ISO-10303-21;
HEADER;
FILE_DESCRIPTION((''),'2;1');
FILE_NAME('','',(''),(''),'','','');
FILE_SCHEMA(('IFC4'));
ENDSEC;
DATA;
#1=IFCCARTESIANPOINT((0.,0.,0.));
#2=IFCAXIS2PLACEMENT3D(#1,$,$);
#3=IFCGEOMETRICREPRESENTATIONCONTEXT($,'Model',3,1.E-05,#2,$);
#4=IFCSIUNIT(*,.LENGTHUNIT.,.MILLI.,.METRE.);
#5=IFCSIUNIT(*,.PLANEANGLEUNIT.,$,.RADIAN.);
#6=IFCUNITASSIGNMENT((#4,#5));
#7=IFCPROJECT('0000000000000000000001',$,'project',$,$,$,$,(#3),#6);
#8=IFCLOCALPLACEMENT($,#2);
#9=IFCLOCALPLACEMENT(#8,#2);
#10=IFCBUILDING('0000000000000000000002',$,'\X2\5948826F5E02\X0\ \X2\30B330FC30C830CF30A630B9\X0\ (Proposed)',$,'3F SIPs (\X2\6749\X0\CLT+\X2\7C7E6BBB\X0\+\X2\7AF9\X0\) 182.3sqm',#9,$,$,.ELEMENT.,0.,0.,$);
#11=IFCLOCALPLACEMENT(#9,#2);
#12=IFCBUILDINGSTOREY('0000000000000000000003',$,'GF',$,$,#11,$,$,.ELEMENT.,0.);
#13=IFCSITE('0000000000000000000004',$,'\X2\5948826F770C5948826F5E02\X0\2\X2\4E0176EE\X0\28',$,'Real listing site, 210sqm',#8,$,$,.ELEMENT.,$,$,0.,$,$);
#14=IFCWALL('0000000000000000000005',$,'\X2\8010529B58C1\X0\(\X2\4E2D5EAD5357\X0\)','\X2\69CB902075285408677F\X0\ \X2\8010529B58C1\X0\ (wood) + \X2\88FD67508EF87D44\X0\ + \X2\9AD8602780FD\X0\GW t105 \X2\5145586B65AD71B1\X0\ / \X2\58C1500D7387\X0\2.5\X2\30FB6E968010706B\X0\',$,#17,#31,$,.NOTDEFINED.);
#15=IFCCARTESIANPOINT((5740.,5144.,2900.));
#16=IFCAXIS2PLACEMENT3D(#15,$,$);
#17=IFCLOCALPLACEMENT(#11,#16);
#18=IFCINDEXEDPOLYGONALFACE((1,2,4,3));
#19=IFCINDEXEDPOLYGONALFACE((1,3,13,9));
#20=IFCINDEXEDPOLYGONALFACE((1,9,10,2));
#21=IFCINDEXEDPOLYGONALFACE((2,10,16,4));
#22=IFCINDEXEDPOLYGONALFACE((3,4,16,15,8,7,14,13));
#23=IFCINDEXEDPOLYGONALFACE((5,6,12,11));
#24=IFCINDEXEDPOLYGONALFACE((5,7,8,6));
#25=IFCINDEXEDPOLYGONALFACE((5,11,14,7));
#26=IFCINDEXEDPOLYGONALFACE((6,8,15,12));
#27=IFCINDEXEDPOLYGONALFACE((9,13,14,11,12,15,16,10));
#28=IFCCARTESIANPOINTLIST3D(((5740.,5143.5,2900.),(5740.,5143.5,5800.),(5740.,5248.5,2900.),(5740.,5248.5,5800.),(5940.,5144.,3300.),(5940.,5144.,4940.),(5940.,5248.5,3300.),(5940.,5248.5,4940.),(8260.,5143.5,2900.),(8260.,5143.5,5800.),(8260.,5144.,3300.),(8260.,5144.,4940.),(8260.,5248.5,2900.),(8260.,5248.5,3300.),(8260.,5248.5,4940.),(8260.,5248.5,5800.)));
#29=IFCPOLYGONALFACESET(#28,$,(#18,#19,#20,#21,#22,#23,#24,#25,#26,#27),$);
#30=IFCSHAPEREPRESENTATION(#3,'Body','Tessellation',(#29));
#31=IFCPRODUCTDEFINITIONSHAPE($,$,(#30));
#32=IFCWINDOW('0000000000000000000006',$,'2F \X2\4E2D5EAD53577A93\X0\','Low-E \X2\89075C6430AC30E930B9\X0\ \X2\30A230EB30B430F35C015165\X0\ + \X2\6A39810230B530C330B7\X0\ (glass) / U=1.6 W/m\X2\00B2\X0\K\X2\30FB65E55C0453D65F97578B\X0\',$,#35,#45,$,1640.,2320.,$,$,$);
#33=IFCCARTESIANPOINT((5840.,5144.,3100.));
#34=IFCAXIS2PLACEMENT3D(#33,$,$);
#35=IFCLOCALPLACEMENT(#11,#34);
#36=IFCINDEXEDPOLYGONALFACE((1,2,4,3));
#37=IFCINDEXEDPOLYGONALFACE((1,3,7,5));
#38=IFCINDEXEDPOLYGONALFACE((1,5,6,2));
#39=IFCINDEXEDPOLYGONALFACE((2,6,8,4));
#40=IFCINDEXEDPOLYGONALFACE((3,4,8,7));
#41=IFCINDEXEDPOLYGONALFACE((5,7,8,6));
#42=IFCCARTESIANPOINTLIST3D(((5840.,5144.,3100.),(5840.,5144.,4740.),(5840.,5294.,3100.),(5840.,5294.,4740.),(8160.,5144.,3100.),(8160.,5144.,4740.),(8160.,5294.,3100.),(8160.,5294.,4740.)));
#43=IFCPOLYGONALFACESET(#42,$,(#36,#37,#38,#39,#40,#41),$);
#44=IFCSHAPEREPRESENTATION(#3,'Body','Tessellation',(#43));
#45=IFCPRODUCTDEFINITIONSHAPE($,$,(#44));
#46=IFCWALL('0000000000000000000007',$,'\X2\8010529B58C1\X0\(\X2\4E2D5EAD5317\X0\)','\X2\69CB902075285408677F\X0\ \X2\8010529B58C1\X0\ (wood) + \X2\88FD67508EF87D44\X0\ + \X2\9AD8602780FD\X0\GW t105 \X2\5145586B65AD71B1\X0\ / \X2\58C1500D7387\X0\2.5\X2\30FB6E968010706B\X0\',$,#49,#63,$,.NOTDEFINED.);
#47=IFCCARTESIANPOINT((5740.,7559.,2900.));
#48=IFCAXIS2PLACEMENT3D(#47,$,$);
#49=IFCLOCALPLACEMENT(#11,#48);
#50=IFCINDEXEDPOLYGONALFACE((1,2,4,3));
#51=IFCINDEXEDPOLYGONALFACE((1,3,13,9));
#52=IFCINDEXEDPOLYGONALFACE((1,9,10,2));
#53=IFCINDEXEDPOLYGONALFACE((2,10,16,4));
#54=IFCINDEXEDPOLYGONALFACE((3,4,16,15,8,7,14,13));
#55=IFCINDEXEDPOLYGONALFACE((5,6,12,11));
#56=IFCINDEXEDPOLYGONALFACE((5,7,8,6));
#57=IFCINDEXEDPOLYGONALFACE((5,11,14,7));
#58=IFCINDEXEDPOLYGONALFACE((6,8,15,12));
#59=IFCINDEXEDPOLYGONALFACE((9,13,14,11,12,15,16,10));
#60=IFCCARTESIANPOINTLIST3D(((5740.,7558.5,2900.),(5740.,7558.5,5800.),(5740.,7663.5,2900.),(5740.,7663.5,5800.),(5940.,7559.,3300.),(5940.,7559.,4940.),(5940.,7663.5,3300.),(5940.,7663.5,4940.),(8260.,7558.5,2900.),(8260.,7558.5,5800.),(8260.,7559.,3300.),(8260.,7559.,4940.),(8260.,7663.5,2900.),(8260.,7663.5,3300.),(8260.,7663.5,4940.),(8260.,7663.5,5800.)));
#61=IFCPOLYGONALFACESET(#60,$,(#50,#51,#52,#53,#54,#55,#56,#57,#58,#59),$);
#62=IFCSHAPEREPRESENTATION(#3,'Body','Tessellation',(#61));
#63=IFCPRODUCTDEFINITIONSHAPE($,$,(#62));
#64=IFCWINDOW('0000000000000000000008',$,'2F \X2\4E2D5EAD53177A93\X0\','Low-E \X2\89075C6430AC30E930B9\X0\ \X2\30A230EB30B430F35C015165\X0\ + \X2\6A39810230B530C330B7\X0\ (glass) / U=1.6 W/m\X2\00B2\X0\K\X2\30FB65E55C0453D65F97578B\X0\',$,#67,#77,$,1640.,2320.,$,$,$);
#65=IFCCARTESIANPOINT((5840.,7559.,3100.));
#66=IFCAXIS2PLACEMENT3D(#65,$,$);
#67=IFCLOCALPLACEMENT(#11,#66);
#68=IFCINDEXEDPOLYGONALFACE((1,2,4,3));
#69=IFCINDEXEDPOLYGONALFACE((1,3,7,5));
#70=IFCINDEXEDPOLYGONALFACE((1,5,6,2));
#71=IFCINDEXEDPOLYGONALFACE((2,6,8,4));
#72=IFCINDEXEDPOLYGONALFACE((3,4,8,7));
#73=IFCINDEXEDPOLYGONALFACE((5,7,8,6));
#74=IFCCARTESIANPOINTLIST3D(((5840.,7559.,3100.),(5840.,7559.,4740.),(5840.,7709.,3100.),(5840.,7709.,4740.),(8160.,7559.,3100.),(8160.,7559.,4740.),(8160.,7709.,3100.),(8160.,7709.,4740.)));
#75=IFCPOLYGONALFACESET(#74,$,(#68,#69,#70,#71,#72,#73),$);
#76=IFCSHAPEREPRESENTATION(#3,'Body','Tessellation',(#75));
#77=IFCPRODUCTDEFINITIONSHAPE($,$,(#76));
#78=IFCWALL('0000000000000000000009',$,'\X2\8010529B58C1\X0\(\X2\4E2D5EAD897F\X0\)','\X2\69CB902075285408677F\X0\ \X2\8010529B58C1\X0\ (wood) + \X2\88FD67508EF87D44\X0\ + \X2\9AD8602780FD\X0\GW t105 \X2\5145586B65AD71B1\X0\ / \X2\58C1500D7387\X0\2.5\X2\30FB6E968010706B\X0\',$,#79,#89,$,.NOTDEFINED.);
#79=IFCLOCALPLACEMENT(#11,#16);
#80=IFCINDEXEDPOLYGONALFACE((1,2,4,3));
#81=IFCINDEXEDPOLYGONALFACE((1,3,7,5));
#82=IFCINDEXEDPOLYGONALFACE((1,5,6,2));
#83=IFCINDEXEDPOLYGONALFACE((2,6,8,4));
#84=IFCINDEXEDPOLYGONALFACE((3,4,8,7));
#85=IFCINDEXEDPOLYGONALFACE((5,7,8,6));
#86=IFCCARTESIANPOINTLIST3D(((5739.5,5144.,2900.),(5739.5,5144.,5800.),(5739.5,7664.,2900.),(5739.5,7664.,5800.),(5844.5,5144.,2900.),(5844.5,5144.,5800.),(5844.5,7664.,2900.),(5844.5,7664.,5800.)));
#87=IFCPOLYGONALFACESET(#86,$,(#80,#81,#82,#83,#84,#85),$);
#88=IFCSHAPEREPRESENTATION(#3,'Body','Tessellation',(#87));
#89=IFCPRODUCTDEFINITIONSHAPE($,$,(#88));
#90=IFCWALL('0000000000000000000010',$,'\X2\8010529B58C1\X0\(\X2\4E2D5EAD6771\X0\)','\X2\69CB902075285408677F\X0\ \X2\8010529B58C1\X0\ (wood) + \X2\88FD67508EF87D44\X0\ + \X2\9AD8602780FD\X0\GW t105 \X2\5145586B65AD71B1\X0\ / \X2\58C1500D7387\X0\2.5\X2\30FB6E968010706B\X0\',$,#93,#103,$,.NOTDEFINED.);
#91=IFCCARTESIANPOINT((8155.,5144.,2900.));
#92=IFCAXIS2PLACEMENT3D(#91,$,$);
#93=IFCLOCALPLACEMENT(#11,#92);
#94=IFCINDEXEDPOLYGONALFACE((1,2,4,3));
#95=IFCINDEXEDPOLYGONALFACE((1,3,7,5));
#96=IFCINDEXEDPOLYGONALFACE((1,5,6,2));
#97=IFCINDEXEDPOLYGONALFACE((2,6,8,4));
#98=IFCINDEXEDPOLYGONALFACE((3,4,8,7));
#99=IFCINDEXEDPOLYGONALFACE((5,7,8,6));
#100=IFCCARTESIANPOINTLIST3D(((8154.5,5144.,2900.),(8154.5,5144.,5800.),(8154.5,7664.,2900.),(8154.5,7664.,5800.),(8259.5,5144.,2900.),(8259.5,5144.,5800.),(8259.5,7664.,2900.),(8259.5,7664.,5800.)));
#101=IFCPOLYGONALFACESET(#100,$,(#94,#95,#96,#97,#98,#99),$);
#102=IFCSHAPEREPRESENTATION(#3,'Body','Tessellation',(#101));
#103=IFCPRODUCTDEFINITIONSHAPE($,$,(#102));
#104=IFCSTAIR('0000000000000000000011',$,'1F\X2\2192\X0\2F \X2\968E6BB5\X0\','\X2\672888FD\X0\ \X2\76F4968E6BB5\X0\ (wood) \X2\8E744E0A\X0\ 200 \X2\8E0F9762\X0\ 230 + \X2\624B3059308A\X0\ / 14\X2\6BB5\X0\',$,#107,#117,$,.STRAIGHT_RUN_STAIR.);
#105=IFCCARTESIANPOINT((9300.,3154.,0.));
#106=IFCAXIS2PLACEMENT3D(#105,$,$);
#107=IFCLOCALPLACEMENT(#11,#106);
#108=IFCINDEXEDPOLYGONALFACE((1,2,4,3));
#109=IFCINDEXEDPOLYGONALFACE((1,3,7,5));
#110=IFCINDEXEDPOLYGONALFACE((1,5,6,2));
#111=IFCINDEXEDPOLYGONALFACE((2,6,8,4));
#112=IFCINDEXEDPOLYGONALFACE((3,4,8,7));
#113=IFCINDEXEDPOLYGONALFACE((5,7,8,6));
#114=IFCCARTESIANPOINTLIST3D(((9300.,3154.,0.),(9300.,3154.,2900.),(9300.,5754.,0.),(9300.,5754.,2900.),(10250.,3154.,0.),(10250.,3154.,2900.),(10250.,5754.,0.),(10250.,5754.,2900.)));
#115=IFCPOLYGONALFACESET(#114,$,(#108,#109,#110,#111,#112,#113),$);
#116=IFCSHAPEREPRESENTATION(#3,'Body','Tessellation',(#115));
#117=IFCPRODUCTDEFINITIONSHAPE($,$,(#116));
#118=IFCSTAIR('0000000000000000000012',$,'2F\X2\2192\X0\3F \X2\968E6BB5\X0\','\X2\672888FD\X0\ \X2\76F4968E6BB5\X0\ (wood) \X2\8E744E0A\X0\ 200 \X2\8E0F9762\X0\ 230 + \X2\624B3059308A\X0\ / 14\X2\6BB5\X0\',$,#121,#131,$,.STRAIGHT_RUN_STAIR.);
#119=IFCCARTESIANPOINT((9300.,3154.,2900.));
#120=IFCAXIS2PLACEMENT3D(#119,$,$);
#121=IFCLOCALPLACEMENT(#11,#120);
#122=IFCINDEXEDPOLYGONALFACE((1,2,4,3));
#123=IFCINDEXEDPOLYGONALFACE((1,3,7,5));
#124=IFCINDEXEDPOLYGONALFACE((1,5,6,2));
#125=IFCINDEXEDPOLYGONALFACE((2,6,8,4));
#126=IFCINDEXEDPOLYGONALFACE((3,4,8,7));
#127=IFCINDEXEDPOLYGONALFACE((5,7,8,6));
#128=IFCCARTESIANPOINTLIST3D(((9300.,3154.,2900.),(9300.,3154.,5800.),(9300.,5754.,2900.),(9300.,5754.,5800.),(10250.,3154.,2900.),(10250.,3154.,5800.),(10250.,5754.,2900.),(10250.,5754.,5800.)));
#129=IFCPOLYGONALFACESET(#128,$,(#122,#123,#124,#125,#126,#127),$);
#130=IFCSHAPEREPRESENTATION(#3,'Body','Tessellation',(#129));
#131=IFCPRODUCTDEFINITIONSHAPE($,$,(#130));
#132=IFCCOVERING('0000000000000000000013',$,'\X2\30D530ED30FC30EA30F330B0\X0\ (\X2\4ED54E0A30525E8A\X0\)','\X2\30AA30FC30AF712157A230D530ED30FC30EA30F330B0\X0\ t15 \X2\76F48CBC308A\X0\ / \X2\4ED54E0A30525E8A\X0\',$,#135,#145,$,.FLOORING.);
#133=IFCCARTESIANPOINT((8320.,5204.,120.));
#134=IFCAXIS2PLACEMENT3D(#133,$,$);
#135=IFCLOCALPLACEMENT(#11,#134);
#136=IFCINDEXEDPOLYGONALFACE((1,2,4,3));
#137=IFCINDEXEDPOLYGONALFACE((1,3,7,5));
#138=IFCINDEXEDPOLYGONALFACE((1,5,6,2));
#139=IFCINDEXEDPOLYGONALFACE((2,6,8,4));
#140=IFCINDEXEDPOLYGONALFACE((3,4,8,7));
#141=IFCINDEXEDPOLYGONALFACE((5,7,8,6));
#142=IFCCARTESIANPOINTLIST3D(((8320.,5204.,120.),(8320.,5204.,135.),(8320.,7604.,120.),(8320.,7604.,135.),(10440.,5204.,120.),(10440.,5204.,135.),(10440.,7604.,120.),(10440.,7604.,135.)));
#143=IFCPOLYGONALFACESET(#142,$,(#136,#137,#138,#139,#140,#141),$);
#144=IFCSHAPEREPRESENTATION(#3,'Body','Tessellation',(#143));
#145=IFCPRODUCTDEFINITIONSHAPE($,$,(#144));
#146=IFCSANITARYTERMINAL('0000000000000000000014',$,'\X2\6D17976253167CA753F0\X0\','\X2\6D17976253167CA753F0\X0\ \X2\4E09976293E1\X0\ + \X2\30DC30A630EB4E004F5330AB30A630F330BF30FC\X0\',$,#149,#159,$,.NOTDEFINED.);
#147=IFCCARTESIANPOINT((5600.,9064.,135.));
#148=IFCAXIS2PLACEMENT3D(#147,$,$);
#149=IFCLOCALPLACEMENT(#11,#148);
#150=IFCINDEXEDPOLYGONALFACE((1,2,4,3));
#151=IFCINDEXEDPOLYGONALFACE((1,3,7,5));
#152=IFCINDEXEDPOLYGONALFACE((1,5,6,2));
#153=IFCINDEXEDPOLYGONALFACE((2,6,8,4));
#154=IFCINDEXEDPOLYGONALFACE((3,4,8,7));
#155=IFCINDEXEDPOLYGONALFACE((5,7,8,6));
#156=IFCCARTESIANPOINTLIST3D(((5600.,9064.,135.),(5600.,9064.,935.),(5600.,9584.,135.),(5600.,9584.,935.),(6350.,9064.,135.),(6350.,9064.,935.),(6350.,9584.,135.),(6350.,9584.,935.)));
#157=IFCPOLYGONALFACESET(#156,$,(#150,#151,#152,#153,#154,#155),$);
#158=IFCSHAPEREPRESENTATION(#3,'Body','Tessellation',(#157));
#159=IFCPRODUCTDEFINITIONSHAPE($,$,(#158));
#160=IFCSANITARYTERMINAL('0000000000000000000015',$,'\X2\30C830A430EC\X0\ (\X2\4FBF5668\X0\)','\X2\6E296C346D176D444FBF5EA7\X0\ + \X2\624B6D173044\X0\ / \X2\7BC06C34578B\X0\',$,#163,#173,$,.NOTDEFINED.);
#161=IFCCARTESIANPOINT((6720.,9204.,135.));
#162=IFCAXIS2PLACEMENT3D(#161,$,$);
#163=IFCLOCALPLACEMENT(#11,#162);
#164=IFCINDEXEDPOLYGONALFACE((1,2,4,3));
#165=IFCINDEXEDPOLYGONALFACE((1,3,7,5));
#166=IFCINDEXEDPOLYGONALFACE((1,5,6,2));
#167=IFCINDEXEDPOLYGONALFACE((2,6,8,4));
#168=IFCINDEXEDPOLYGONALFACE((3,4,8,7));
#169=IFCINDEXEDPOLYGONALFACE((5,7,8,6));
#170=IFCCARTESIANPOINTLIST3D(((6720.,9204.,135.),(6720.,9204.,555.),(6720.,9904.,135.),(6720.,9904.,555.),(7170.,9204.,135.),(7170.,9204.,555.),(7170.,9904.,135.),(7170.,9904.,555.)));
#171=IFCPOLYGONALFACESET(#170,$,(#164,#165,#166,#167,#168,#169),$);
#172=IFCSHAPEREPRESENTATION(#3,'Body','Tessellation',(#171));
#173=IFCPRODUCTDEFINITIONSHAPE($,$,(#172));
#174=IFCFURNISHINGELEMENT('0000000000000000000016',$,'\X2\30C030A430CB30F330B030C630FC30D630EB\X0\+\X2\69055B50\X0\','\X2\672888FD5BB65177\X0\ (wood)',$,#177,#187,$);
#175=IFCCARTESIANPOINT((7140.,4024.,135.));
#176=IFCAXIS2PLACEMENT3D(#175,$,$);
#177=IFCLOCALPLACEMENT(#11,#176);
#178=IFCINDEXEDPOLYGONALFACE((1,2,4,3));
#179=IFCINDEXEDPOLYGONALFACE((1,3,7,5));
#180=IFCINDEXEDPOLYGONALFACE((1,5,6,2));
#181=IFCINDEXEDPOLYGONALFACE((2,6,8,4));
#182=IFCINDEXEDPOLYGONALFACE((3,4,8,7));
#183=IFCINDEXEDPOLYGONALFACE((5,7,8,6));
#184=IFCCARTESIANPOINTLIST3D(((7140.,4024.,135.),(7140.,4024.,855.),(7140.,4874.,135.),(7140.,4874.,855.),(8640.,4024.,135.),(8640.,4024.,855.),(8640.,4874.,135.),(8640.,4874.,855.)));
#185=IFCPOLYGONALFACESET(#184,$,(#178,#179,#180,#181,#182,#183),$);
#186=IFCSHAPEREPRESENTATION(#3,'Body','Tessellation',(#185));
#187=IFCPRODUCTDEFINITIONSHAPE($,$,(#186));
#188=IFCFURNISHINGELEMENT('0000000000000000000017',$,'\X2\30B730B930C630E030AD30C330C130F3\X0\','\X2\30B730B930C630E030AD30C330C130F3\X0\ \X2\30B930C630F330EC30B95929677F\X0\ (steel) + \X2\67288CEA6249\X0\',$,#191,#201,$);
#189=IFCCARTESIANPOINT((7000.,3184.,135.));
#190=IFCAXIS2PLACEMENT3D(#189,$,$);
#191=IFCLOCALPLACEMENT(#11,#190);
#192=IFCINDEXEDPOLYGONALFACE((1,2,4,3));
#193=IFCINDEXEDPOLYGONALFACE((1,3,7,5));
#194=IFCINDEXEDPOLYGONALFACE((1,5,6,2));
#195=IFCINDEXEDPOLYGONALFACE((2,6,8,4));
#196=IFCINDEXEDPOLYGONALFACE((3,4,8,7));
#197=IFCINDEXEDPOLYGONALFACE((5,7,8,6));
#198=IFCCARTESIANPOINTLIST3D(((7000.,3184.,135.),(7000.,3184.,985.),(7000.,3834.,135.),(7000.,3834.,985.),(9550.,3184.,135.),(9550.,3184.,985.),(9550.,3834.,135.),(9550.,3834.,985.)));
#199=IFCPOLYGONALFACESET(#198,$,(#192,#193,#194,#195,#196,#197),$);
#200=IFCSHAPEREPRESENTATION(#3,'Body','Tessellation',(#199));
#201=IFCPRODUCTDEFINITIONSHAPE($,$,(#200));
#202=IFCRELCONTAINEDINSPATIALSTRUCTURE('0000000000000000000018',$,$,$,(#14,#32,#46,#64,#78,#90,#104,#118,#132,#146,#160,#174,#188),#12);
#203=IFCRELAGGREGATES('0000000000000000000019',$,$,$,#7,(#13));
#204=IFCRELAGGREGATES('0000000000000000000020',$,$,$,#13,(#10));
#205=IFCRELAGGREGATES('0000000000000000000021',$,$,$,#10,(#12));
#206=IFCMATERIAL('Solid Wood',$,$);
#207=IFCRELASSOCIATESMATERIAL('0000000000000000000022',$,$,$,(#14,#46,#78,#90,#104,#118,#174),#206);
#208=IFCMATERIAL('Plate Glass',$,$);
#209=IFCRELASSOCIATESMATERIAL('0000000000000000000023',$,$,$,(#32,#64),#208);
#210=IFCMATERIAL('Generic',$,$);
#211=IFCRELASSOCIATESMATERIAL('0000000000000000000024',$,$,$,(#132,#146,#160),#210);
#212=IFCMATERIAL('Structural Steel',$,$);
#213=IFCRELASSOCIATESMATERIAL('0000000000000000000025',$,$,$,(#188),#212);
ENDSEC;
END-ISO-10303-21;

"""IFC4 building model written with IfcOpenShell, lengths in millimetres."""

from ifc_helpers import new_model, si_unit, frame, frame_2d, origin, place, context, project, spatial, rectangle, extrude, material, element, fill, save


model = new_model("IFC4")

# Units and contexts
model_context = context("Model", 3, precision=1e-05, world=origin())
ifc_project = project(units=[si_unit("LENGTHUNIT", "METRE", prefix="MILLI"), si_unit("PLANEANGLEUNIT", "RADIAN")], contexts=[model_context])

# Site, building, storey
site_placement = place(None, origin())
site = spatial("IfcSite", under=ifc_project, at=site_placement, Name="奈良県奈良市2丁目28", ObjectType="Real listing site, 210sqm", CompositionType="ELEMENT", RefElevation=0.0)
building_placement = place(site_placement, origin())
building = spatial("IfcBuilding", under=site, at=building_placement, Name="奈良市 コートハウス (Proposed)", ObjectType="3F SIPs (杉CLT+籾殻+竹) 182.3sqm", CompositionType="ELEMENT", ElevationOfRefHeight=0.0, ElevationOfTerrain=0.0)
storey_placement = place(building_placement, origin())
storey = spatial("IfcBuildingStorey", under=building, at=storey_placement, Name="GF", CompositionType="ELEMENT", Elevation=0.0)

# Shared definitions
ifc_material_1 = material(Name="Solid Wood")

# Shared definitions
ifc_material_2 = material(Name="Plate Glass")

# Walls, openings, windows
wall_1_placement = place(storey_placement, frame((5740.0, 5144.0, 2900.0)))
wall_1 = element("IfcWall", 1, at=wall_1_placement, inside=storey, material=ifc_material_1, Name="耐力壁(中庭南)", Description="構造用合板 耐力壁 (wood) + 製材軸組 + 高性能GW t105 充填断熱 / 壁倍率2.5・準耐火", PredefinedType="NOTDEFINED", context=model_context, shape_type="SweptSolid", body=[
    extrude(rectangle(XDim=2520.0, YDim=105.0, at=frame_2d((1260.0, 52.0))), frame((5740.0, 5144.0, 2900.0)), (0.0, 0.0, 1.0), 2900.0),
])
opening_1_placement = place(storey_placement, frame((5840.0, 5144.0, 3100.0)))
opening_1 = element("IfcOpeningElement", 2, at=opening_1_placement, cuts=wall_1, PredefinedType="NOTDEFINED", context=model_context, shape_type="SweptSolid", body=[
    extrude(rectangle(XDim=2320.0, YDim=150.0, at=frame_2d((1160.0, 75.0))), frame((5840.0, 5144.0, 3100.0)), (0.0, 0.0, 1.0), 1640.0),
])
window_1_placement = place(storey_placement, frame((5840.0, 5144.0, 3100.0)))
window_1 = element("IfcWindow", 3, at=window_1_placement, inside=storey, material=ifc_material_2, Name="2F 中庭南窓", Description="Low-E 複層ガラス アルゴン封入 + 樹脂サッシ (glass) / U=1.6 W/m²K・日射取得型", OverallHeight=1640.0, OverallWidth=2320.0, context=model_context, shape_type="SweptSolid", body=[
    extrude(rectangle(XDim=2320.0, YDim=150.0, at=frame_2d((1160.0, 75.0))), frame((5840.0, 5144.0, 3100.0)), (0.0, 0.0, 1.0), 1640.0),
])
fill(opening_1, window_1)
wall_2_placement = place(storey_placement, frame((5740.0, 7559.0, 2900.0)))
wall_2 = element("IfcWall", 4, at=wall_2_placement, inside=storey, material=ifc_material_1, Name="耐力壁(中庭北)", Description="構造用合板 耐力壁 (wood) + 製材軸組 + 高性能GW t105 充填断熱 / 壁倍率2.5・準耐火", PredefinedType="NOTDEFINED", context=model_context, shape_type="SweptSolid", body=[
    extrude(rectangle(XDim=2520.0, YDim=105.0, at=frame_2d((1260.0, 52.0))), frame((5740.0, 7559.0, 2900.0)), (0.0, 0.0, 1.0), 2900.0),
])
opening_2_placement = place(storey_placement, frame((5840.0, 7559.0, 3100.0)))
opening_2 = element("IfcOpeningElement", 5, at=opening_2_placement, cuts=wall_2, PredefinedType="NOTDEFINED", context=model_context, shape_type="SweptSolid", body=[
    extrude(rectangle(XDim=2320.0, YDim=150.0, at=frame_2d((1160.0, 75.0))), frame((5840.0, 7559.0, 3100.0)), (0.0, 0.0, 1.0), 1640.0),
])
window_2_placement = place(storey_placement, frame((5840.0, 7559.0, 3100.0)))
window_2 = element("IfcWindow", 6, at=window_2_placement, inside=storey, material=ifc_material_2, Name="2F 中庭北窓", Description="Low-E 複層ガラス アルゴン封入 + 樹脂サッシ (glass) / U=1.6 W/m²K・日射取得型", OverallHeight=1640.0, OverallWidth=2320.0, context=model_context, shape_type="SweptSolid", body=[
    extrude(rectangle(XDim=2320.0, YDim=150.0, at=frame_2d((1160.0, 75.0))), frame((5840.0, 7559.0, 3100.0)), (0.0, 0.0, 1.0), 1640.0),
])
fill(opening_2, window_2)

# Walls
wall_3_placement = place(storey_placement, frame((5740.0, 5144.0, 2900.0)))
element("IfcWall", 7, at=wall_3_placement, inside=storey, material=ifc_material_1, Name="耐力壁(中庭西)", Description="構造用合板 耐力壁 (wood) + 製材軸組 + 高性能GW t105 充填断熱 / 壁倍率2.5・準耐火", PredefinedType="NOTDEFINED", context=model_context, shape_type="SweptSolid", body=[
    extrude(rectangle(XDim=105.0, YDim=2520.0, at=frame_2d((52.0, 1260.0))), frame((5740.0, 5144.0, 2900.0)), (0.0, 0.0, 1.0), 2900.0),
])
wall_4_placement = place(storey_placement, frame((8155.0, 5144.0, 2900.0)))
element("IfcWall", 8, at=wall_4_placement, inside=storey, material=ifc_material_1, Name="耐力壁(中庭東)", Description="構造用合板 耐力壁 (wood) + 製材軸組 + 高性能GW t105 充填断熱 / 壁倍率2.5・準耐火", PredefinedType="NOTDEFINED", context=model_context, shape_type="SweptSolid", body=[
    extrude(rectangle(XDim=105.0, YDim=2520.0, at=frame_2d((52.0, 1260.0))), frame((8155.0, 5144.0, 2900.0)), (0.0, 0.0, 1.0), 2900.0),
])

# Stairs
stair_1_placement = place(storey_placement, frame((9300.0, 3154.0, 0.0)))
element("IfcStair", 9, at=stair_1_placement, inside=storey, material=ifc_material_1, Name="1F→2F 階段", Description="木製 直階段 (wood) 蹴上 200 踏面 230 + 手すり / 14段", PredefinedType="STRAIGHT_RUN_STAIR", context=model_context, shape_type="SweptSolid", body=[
    extrude(rectangle(XDim=950.0, YDim=2600.0, at=frame_2d((475.0, 1300.0))), frame((9300.0, 3154.0, 0.0)), (0.0, 0.0, 1.0), 2900.0),
])
stair_2_placement = place(storey_placement, frame((9300.0, 3154.0, 2900.0)))
element("IfcStair", 10, at=stair_2_placement, inside=storey, material=ifc_material_1, Name="2F→3F 階段", Description="木製 直階段 (wood) 蹴上 200 踏面 230 + 手すり / 14段", PredefinedType="STRAIGHT_RUN_STAIR", context=model_context, shape_type="SweptSolid", body=[
    extrude(rectangle(XDim=950.0, YDim=2600.0, at=frame_2d((475.0, 1300.0))), frame((9300.0, 3154.0, 2900.0)), (0.0, 0.0, 1.0), 2900.0),
])

# Covering
ifc_material_3 = material(Name="Generic")
covering_placement = place(storey_placement, frame((8320.0, 5204.0, 120.0)))
element("IfcCovering", 11, at=covering_placement, inside=storey, material=ifc_material_3, Name="フローリング (仕上げ床)", Description="オーク無垢フローリング t15 直貼り / 仕上げ床", PredefinedType="FLOORING", context=model_context, shape_type="SweptSolid", body=[
    extrude(rectangle(XDim=2120.0, YDim=2400.0, at=frame_2d((1060.0, 1200.0))), frame((8320.0, 5204.0, 120.0)), (0.0, 0.0, 1.0), 15.0),
])

# Sanitary terminals
sanitary_terminal_1_placement = place(storey_placement, frame((5600.0, 9064.0, 135.0)))
element("IfcSanitaryTerminal", 12, at=sanitary_terminal_1_placement, inside=storey, material=ifc_material_3, Name="洗面化粧台", Description="洗面化粧台 三面鏡 + ボウル一体カウンター", PredefinedType="NOTDEFINED", context=model_context, shape_type="SweptSolid", body=[
    extrude(rectangle(XDim=750.0, YDim=520.0, at=frame_2d((375.0, 260.0))), frame((5600.0, 9064.0, 135.0)), (0.0, 0.0, 1.0), 800.0),
])
sanitary_terminal_2_placement = place(storey_placement, frame((6720.0, 9204.0, 135.0)))
element("IfcSanitaryTerminal", 13, at=sanitary_terminal_2_placement, inside=storey, material=ifc_material_3, Name="トイレ (便器)", Description="温水洗浄便座 + 手洗い / 節水型", PredefinedType="NOTDEFINED", context=model_context, shape_type="SweptSolid", body=[
    extrude(rectangle(XDim=450.0, YDim=700.0, at=frame_2d((225.0, 350.0))), frame((6720.0, 9204.0, 135.0)), (0.0, 0.0, 1.0), 420.0),
])

# Furnishing elements
furnishing_1_placement = place(storey_placement, frame((7140.0, 4024.0, 135.0)))
element("IfcFurnishingElement", 14, at=furnishing_1_placement, inside=storey, material=ifc_material_1, Name="ダイニングテーブル+椅子", Description="木製家具 (wood)", context=model_context, shape_type="SweptSolid", body=[
    extrude(rectangle(XDim=1500.0, YDim=850.0, at=frame_2d((750.0, 425.0))), frame((7140.0, 4024.0, 135.0)), (0.0, 0.0, 1.0), 720.0),
])
ifc_material_4 = material(Name="Structural Steel")
furnishing_2_placement = place(storey_placement, frame((7000.0, 3184.0, 135.0)))
element("IfcFurnishingElement", 15, at=furnishing_2_placement, inside=storey, material=ifc_material_4, Name="システムキッチン", Description="システムキッチン ステンレス天板 (steel) + 木質扉", context=model_context, shape_type="SweptSolid", body=[
    extrude(rectangle(XDim=2550.0, YDim=650.0, at=frame_2d((1275.0, 325.0))), frame((7000.0, 3184.0, 135.0)), (0.0, 0.0, 1.0), 850.0),
])

save(model, "model.ifc")
